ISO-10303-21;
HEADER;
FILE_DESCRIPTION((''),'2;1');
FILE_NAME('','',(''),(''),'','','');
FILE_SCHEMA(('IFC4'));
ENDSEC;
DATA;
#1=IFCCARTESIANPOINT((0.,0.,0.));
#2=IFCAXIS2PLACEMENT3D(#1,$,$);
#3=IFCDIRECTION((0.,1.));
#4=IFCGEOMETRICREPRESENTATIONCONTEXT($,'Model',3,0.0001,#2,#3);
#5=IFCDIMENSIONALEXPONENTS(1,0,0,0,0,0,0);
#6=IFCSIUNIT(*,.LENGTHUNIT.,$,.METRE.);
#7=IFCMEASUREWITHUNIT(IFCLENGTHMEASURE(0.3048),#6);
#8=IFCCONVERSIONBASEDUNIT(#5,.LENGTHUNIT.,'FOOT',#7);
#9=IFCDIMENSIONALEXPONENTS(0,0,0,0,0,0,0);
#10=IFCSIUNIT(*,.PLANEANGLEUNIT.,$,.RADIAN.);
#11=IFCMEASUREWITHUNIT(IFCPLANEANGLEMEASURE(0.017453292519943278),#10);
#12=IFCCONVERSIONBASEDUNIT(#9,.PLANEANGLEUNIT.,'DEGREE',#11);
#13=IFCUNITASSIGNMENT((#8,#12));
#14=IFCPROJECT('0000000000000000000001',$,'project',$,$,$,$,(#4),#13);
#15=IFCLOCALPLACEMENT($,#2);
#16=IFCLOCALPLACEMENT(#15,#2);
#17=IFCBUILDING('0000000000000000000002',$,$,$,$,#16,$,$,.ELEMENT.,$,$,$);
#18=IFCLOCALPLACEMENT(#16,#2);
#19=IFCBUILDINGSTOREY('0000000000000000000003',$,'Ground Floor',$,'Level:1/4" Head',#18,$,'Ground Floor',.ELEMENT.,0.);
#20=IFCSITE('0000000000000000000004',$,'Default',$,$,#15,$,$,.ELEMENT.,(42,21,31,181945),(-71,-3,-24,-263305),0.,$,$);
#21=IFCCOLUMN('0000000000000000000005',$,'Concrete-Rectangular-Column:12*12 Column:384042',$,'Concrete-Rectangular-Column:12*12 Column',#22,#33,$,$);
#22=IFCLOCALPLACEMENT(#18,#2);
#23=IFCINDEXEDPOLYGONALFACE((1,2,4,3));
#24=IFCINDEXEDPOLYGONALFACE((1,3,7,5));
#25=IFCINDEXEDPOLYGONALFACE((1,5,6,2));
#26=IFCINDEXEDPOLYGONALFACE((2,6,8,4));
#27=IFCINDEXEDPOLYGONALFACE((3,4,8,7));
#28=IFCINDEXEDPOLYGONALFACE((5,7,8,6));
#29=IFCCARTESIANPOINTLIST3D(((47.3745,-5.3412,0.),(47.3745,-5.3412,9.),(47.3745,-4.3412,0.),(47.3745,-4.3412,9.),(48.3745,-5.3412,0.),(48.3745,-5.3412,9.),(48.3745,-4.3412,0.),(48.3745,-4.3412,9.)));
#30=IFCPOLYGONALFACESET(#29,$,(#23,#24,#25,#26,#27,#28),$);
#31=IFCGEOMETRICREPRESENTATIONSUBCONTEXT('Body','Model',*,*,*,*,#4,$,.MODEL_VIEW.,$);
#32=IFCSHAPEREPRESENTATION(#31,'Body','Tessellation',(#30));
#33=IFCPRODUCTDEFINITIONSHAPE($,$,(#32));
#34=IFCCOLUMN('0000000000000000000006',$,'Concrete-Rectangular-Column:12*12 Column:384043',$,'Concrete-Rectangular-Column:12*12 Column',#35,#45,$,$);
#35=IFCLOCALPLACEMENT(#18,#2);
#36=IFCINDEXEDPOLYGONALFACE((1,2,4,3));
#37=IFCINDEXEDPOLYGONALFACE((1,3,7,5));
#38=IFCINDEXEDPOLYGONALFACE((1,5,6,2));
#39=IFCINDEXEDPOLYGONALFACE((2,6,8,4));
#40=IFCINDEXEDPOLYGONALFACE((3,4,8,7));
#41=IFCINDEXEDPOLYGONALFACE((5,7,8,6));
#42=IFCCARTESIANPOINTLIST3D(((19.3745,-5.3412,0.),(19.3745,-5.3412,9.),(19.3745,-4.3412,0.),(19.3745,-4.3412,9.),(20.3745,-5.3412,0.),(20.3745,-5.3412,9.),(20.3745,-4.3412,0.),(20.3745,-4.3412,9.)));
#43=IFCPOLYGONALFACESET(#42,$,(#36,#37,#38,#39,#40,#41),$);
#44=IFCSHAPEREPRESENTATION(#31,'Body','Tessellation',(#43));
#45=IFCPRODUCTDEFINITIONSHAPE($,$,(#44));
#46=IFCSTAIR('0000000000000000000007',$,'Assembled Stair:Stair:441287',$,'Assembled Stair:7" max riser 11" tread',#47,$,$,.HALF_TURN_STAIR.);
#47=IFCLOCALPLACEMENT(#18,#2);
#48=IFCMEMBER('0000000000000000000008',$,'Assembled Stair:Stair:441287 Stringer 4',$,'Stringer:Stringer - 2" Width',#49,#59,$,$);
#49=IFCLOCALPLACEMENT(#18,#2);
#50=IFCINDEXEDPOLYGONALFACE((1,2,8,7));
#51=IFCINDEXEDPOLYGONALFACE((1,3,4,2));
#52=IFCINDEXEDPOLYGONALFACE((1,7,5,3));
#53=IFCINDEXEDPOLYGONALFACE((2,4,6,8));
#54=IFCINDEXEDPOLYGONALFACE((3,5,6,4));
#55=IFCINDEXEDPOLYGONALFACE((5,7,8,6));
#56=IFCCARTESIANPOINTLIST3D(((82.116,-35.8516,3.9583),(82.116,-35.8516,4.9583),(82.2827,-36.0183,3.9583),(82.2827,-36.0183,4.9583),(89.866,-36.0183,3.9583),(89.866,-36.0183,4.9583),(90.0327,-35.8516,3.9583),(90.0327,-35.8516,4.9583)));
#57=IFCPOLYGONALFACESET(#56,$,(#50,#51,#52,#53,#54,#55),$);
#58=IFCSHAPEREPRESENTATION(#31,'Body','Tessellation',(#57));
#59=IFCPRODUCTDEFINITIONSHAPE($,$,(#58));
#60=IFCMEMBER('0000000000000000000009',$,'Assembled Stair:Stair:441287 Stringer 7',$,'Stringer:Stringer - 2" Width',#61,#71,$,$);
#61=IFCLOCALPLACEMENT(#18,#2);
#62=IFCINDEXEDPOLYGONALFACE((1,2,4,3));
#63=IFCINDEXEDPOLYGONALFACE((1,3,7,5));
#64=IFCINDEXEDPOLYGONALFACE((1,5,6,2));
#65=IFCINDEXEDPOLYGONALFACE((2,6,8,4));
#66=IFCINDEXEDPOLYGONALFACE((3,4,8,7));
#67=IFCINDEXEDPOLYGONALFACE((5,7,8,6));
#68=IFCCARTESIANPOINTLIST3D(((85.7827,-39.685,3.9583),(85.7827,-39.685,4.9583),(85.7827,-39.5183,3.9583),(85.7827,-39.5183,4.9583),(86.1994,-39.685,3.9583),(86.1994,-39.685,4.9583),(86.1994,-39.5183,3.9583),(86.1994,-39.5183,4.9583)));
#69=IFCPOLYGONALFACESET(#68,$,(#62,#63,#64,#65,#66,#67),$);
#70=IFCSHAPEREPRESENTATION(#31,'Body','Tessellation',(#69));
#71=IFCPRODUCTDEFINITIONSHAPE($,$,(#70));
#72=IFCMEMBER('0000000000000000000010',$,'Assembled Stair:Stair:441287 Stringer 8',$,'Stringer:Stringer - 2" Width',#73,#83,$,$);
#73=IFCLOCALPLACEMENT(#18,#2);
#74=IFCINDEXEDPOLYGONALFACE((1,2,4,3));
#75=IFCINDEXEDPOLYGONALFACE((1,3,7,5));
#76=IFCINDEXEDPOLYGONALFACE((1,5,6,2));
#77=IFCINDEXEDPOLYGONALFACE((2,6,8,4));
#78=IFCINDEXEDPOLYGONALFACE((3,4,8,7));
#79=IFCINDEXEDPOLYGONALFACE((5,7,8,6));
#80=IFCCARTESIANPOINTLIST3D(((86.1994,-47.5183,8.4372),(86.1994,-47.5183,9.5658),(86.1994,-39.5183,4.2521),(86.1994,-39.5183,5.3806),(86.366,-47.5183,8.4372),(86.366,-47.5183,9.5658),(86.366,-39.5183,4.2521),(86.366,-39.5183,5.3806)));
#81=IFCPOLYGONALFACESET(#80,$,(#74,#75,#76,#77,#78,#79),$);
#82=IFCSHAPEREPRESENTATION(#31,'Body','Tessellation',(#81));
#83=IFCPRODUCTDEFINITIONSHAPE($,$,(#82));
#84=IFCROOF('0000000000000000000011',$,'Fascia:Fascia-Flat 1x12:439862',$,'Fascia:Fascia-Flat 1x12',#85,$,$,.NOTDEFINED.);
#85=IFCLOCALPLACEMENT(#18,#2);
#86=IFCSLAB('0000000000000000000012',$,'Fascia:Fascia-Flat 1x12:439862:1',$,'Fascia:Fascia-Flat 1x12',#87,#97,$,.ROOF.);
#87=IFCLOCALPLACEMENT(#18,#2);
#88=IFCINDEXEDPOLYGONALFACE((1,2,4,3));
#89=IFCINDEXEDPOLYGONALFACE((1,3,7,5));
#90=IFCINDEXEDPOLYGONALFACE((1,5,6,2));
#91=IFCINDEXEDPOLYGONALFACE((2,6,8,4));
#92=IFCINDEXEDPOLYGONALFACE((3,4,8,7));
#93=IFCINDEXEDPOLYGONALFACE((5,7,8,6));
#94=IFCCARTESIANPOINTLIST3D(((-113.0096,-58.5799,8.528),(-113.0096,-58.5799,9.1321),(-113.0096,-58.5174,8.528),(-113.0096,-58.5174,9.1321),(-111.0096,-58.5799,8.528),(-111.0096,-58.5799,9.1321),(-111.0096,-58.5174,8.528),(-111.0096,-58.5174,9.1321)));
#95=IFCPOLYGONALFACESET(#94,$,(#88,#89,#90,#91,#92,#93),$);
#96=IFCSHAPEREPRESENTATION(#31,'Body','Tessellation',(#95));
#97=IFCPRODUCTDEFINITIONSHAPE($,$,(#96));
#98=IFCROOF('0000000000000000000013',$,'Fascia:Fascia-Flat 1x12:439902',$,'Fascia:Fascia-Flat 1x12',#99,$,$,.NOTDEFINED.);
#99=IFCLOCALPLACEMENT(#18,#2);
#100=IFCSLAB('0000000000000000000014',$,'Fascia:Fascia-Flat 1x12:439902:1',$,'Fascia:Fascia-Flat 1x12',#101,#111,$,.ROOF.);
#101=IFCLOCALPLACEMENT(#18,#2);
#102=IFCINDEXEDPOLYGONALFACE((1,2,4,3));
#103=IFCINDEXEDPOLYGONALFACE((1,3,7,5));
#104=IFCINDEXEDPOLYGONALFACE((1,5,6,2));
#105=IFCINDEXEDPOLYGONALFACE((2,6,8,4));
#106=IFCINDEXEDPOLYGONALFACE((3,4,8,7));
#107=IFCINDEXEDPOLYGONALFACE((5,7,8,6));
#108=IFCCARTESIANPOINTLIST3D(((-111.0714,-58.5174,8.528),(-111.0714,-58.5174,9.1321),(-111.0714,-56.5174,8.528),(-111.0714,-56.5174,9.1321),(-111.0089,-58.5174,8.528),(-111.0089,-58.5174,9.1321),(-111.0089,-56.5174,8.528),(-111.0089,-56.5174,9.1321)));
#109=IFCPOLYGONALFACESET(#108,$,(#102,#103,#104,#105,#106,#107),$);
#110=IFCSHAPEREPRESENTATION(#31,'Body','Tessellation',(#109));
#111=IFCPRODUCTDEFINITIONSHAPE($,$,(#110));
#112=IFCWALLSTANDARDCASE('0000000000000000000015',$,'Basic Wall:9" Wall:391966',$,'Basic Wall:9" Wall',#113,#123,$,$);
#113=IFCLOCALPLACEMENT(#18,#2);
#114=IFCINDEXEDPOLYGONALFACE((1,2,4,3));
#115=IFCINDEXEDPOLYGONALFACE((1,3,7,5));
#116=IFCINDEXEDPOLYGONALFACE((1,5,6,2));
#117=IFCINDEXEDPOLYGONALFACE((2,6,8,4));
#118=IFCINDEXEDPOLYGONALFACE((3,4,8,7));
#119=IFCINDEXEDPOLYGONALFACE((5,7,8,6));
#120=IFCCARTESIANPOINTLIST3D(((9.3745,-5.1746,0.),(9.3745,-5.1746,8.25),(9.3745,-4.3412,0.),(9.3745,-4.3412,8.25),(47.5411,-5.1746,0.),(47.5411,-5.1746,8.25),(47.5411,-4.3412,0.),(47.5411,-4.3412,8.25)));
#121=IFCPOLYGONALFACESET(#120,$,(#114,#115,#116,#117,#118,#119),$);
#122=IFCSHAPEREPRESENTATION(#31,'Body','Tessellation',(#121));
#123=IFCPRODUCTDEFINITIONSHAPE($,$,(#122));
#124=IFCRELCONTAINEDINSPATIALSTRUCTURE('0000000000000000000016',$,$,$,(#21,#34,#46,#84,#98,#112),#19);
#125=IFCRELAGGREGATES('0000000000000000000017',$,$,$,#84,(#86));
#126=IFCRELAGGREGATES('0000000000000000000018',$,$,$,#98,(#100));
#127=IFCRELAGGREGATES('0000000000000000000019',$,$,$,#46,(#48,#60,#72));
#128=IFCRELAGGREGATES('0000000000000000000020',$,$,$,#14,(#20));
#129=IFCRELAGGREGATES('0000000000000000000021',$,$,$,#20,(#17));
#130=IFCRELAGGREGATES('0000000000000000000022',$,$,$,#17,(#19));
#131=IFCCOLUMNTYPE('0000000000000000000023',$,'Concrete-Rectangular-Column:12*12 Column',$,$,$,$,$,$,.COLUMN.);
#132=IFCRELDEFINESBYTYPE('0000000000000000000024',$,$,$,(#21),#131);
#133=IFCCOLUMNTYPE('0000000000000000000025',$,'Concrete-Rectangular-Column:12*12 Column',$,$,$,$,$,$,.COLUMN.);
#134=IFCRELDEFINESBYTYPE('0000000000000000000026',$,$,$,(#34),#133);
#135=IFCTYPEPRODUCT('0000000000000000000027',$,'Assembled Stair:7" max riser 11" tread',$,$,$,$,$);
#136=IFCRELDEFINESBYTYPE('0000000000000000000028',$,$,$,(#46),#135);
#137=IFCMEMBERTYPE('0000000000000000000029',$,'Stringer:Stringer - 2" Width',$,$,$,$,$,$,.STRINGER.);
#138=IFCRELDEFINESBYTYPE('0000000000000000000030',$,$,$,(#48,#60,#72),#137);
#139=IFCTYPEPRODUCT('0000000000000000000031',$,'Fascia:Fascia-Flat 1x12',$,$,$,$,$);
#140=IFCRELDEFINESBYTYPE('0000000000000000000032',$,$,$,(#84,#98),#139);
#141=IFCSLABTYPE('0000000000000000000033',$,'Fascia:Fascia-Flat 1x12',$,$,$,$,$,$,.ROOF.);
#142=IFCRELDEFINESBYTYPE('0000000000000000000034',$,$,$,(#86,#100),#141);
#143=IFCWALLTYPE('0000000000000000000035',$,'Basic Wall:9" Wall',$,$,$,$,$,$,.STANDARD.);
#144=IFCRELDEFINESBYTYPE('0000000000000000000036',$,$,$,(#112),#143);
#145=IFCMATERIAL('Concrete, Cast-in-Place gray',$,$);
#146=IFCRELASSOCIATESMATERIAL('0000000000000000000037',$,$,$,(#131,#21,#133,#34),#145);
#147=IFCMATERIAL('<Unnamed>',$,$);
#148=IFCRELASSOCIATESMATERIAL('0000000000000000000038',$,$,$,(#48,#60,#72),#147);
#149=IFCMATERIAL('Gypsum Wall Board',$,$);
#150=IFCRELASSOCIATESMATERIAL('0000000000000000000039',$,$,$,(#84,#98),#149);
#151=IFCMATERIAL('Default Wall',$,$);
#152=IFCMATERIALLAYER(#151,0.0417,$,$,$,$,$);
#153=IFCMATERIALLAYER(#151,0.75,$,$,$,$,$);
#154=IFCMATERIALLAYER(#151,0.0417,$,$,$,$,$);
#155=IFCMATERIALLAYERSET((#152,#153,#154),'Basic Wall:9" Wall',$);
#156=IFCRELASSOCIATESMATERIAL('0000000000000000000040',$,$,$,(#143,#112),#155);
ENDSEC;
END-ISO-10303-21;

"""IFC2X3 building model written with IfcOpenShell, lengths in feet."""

from ifc_helpers import new_model, entity, si_unit, converted_unit, direction, frame, frame_2d, origin, origin_2d_with_axis, place, context, subcontext, project, spatial, polyline, rectangle, outline, extrude, source, transform, mapped, material, layer, layer_set, layer_usage, type_object, type_shapes, element, aggregate, save


model = new_model("IFC2X3")

# Units and contexts
model_context = context("Model", 3, precision=0.0001, world=origin(), true_north=direction((0.0, 1.0)))
body_context = subcontext(model_context, "Body", "Model", "MODEL_VIEW")
ifc_project = project(units=[converted_unit("LENGTHUNIT", "FOOT", entity("IfcLengthMeasure", 0.3048), si_unit("LENGTHUNIT", "METRE"), dimensions=[1, 0, 0, 0, 0, 0, 0]), converted_unit("PLANEANGLEUNIT", "DEGREE", entity("IfcPlaneAngleMeasure", 0.017453292519943278), si_unit("PLANEANGLEUNIT", "RADIAN"), dimensions=[0, 0, 0, 0, 0, 0, 0])], contexts=[model_context])

# Site, building, storey
site_placement = place(None, origin())
site = spatial("IfcSite", under=ifc_project, at=site_placement, Name="Default", CompositionType="ELEMENT", RefLatitude=(42, 21, 31, 181945), RefLongitude=(-71, -3, -24, -263305), RefElevation=0.0)
building_placement = place(site_placement, origin())
building = spatial("IfcBuilding", under=site, at=building_placement, CompositionType="ELEMENT")
storey_placement = place(building_placement, origin())
storey = spatial("IfcBuildingStorey", under=building, at=storey_placement, Name="Ground Floor", ObjectType="Level:1/4\" Head", LongName="Ground Floor", CompositionType="ELEMENT", Elevation=0.0)

# Columns
ifc_material_1 = material(Name="Concrete, Cast-in-Place gray")
column_type_1 = type_object("IfcColumnType", Name="Concrete-Rectangular-Column:12*12 Column", PredefinedType="COLUMN", material=ifc_material_1)
shared_shape_1 = source(origin(), body_context, "Body", "SweptSolid", [
    extrude(rectangle(XDim=1.0, YDim=1.0, at=frame_2d((0.0, 0.0), x_axis=(1.0, 0.0))), frame((47.8745, -4.8412, 0.0), z_axis=(0.0, 0.0, 1.0), x_axis=(-1.0, 0.0, 0.0)), (0.0, 0.0, 1.0), 9.0),
])
type_shapes(column_type_1, [shared_shape_1])
column_1_placement = place(storey_placement, origin())
element("IfcColumn", 1, at=column_1_placement, inside=storey, type_object=column_type_1, material=ifc_material_1, Name="Concrete-Rectangular-Column:12*12 Column:384042", ObjectType="Concrete-Rectangular-Column:12*12 Column", context=body_context, shape_type="MappedRepresentation", body=[
    mapped(shared_shape_1, transform((0.0, 0.0, 0.0), scale=1.0)),
])
column_type_2 = type_object("IfcColumnType", Name="Concrete-Rectangular-Column:12*12 Column", PredefinedType="COLUMN", material=ifc_material_1)
shared_shape_2 = source(origin(), body_context, "Body", "SweptSolid", [
    extrude(rectangle(XDim=1.0, YDim=1.0, at=frame_2d((0.0, 0.0), x_axis=(1.0, 0.0))), frame((19.8745, -4.8412, 0.0), z_axis=(0.0, 0.0, 1.0), x_axis=(-1.0, 0.0, 0.0)), (0.0, 0.0, 1.0), 9.0),
])
type_shapes(column_type_2, [shared_shape_2])
column_2_placement = place(storey_placement, origin())
element("IfcColumn", 2, at=column_2_placement, inside=storey, type_object=column_type_2, material=ifc_material_1, Name="Concrete-Rectangular-Column:12*12 Column:384043", ObjectType="Concrete-Rectangular-Column:12*12 Column", context=body_context, shape_type="MappedRepresentation", body=[
    mapped(shared_shape_2, transform((0.0, 0.0, 0.0), scale=1.0)),
])

# Stair, members
type_product_1 = type_object("IfcTypeProduct", Name="Assembled Stair:7\" max riser 11\" tread")
stair_placement = place(storey_placement, origin())
stair = element("IfcStair", 3, at=stair_placement, inside=storey, type_object=type_product_1, Name="Assembled Stair:Stair:441287", ObjectType="Assembled Stair:7\" max riser 11\" tread", ShapeType="HALF_TURN_STAIR")
ifc_material_2 = material(Name="<Unnamed>")
member_type = type_object("IfcMemberType", Name="Stringer:Stringer - 2\" Width", PredefinedType="STRINGER")
member_1_placement = place(stair_placement, origin())
member_1 = element("IfcMember", 4, at=member_1_placement, type_object=member_type, material=ifc_material_2, Name="Assembled Stair:Stair:441287 Stringer 4", ObjectType="Stringer:Stringer - 2\" Width", context=body_context, shape_type="SweptSolid", body=[
    extrude(outline(polyline([(-3.9583, -0.0833), (3.9583, -0.0833), (3.7917, 0.0833), (-3.7917, 0.0833), (-3.9583, -0.0833)])), frame((86.0744, -35.935, 3.9583), z_axis=(0.0, 0.0, 1.0), x_axis=(-1.0, 0.0, 0.0)), (0.0, 0.0, 1.0), 1.0),
])
member_2_placement = place(stair_placement, origin())
member_2 = element("IfcMember", 5, at=member_2_placement, type_object=member_type, material=ifc_material_2, Name="Assembled Stair:Stair:441287 Stringer 7", ObjectType="Stringer:Stringer - 2\" Width", context=body_context, shape_type="SweptSolid", body=[
    extrude(rectangle(XDim=0.4167, YDim=0.1667, at=frame_2d((0.0, 0.0), x_axis=(1.0, 0.0))), frame((85.991, -39.6016, 3.9583)), (0.0, 0.0, 1.0), 1.0),
])
member_3_placement = place(stair_placement, origin())
member_3 = element("IfcMember", 6, at=member_3_placement, type_object=member_type, material=ifc_material_2, Name="Assembled Stair:Stair:441287 Stringer 8", ObjectType="Stringer:Stringer - 2\" Width", context=body_context, shape_type="SweptSolid", body=[
    extrude(outline(polyline([(-4.2527, -0.5), (4.7759, -0.5), (4.2527, 0.5), (-4.7759, 0.5), (-4.2527, -0.5)])), frame((86.1994, -43.5183, 6.9089), z_axis=(1.0, 0.0, 0.0), x_axis=(0.0, -0.886072, 0.463547)), (0.0, 0.0, 1.0), 0.1667),
])

# Roofs, slabs
ifc_material_3 = material(Name="Gypsum Wall Board")
type_product_2 = type_object("IfcTypeProduct", Name="Fascia:Fascia-Flat 1x12")
roof_1_placement = place(storey_placement, origin())
roof_1 = element("IfcRoof", 7, at=roof_1_placement, inside=storey, type_object=type_product_2, material=ifc_material_3, Name="Fascia:Fascia-Flat 1x12:439862", ObjectType="Fascia:Fascia-Flat 1x12", ShapeType="NOTDEFINED")
slab_type_1 = type_object("IfcSlabType", Name="Fascia:Fascia-Flat 1x12", PredefinedType="ROOF")
slab_1_placement = place(storey_placement, origin())
slab_1 = element("IfcSlab", 8, at=slab_1_placement, type_object=slab_type_1, Name="Fascia:Fascia-Flat 1x12:439862:1", ObjectType="Fascia:Fascia-Flat 1x12", PredefinedType="ROOF", context=body_context, shape_type="SweptSolid", body=[
    extrude(rectangle(XDim=2.0, YDim=0.0625, at=frame_2d((0.0, 0.0), x_axis=(1.0, 0.0))), frame((-112.0096, -58.5487, 8.528)), (0.0, 0.0, 1.0), 0.6042),
])
aggregate(roof_1, [slab_1])
roof_2_placement = place(storey_placement, origin())
roof_2 = element("IfcRoof", 9, at=roof_2_placement, inside=storey, type_object=type_product_2, material=ifc_material_3, Name="Fascia:Fascia-Flat 1x12:439902", ObjectType="Fascia:Fascia-Flat 1x12", ShapeType="NOTDEFINED")
slab_2_placement = place(storey_placement, origin())
slab_2 = element("IfcSlab", 10, at=slab_2_placement, type_object=slab_type_1, Name="Fascia:Fascia-Flat 1x12:439902:1", ObjectType="Fascia:Fascia-Flat 1x12", PredefinedType="ROOF", context=body_context, shape_type="SweptSolid", body=[
    extrude(rectangle(XDim=2.0, YDim=0.0625, at=origin_2d_with_axis()), frame((-111.0402, -57.5174, 8.528), z_axis=(0.0, 0.0, 1.0), x_axis=(0.0, 1.0, 0.0)), (0.0, 0.0, 1.0), 0.6042),
])
aggregate(roof_2, [slab_2])

# Wall
ifc_material_4 = material(Name="Default Wall")
ifc_layer_1 = layer(ifc_material_4, 0.0417)
ifc_layer_2 = layer(ifc_material_4, 0.75)
ifc_layer_3 = layer(ifc_material_4, 0.0417)
ifc_layer_set_1 = layer_set([ifc_layer_1, ifc_layer_2, ifc_layer_3], Name="Basic Wall:9\" Wall")
ifc_layer_usage_1 = layer_usage(ifc_layer_set_1, "AXIS2", "NEGATIVE", 0.4167)
wall_type_1 = type_object("IfcWallType", Name="Basic Wall:9\" Wall", PredefinedType="STANDARD", material=ifc_layer_set_1)
wall_1_placement = place(storey_placement, frame((9.3745, -4.7579, 0.0)))
element("IfcWallStandardCase", 11, at=wall_1_placement, inside=storey, type_object=wall_type_1, material=ifc_layer_usage_1, Name="Basic Wall:9\" Wall:391966", ObjectType="Basic Wall:9\" Wall", context=body_context, shape_type="SweptSolid", body=[
    extrude(rectangle(XDim=38.1667, YDim=0.8333, at=frame_2d((19.0833, 0.0), x_axis=(-1.0, 0.0))), origin(), (0.0, 0.0, 1.0), 8.25),
])

aggregate(stair, [member_1, member_2, member_3])

save(model, "model.ifc")
